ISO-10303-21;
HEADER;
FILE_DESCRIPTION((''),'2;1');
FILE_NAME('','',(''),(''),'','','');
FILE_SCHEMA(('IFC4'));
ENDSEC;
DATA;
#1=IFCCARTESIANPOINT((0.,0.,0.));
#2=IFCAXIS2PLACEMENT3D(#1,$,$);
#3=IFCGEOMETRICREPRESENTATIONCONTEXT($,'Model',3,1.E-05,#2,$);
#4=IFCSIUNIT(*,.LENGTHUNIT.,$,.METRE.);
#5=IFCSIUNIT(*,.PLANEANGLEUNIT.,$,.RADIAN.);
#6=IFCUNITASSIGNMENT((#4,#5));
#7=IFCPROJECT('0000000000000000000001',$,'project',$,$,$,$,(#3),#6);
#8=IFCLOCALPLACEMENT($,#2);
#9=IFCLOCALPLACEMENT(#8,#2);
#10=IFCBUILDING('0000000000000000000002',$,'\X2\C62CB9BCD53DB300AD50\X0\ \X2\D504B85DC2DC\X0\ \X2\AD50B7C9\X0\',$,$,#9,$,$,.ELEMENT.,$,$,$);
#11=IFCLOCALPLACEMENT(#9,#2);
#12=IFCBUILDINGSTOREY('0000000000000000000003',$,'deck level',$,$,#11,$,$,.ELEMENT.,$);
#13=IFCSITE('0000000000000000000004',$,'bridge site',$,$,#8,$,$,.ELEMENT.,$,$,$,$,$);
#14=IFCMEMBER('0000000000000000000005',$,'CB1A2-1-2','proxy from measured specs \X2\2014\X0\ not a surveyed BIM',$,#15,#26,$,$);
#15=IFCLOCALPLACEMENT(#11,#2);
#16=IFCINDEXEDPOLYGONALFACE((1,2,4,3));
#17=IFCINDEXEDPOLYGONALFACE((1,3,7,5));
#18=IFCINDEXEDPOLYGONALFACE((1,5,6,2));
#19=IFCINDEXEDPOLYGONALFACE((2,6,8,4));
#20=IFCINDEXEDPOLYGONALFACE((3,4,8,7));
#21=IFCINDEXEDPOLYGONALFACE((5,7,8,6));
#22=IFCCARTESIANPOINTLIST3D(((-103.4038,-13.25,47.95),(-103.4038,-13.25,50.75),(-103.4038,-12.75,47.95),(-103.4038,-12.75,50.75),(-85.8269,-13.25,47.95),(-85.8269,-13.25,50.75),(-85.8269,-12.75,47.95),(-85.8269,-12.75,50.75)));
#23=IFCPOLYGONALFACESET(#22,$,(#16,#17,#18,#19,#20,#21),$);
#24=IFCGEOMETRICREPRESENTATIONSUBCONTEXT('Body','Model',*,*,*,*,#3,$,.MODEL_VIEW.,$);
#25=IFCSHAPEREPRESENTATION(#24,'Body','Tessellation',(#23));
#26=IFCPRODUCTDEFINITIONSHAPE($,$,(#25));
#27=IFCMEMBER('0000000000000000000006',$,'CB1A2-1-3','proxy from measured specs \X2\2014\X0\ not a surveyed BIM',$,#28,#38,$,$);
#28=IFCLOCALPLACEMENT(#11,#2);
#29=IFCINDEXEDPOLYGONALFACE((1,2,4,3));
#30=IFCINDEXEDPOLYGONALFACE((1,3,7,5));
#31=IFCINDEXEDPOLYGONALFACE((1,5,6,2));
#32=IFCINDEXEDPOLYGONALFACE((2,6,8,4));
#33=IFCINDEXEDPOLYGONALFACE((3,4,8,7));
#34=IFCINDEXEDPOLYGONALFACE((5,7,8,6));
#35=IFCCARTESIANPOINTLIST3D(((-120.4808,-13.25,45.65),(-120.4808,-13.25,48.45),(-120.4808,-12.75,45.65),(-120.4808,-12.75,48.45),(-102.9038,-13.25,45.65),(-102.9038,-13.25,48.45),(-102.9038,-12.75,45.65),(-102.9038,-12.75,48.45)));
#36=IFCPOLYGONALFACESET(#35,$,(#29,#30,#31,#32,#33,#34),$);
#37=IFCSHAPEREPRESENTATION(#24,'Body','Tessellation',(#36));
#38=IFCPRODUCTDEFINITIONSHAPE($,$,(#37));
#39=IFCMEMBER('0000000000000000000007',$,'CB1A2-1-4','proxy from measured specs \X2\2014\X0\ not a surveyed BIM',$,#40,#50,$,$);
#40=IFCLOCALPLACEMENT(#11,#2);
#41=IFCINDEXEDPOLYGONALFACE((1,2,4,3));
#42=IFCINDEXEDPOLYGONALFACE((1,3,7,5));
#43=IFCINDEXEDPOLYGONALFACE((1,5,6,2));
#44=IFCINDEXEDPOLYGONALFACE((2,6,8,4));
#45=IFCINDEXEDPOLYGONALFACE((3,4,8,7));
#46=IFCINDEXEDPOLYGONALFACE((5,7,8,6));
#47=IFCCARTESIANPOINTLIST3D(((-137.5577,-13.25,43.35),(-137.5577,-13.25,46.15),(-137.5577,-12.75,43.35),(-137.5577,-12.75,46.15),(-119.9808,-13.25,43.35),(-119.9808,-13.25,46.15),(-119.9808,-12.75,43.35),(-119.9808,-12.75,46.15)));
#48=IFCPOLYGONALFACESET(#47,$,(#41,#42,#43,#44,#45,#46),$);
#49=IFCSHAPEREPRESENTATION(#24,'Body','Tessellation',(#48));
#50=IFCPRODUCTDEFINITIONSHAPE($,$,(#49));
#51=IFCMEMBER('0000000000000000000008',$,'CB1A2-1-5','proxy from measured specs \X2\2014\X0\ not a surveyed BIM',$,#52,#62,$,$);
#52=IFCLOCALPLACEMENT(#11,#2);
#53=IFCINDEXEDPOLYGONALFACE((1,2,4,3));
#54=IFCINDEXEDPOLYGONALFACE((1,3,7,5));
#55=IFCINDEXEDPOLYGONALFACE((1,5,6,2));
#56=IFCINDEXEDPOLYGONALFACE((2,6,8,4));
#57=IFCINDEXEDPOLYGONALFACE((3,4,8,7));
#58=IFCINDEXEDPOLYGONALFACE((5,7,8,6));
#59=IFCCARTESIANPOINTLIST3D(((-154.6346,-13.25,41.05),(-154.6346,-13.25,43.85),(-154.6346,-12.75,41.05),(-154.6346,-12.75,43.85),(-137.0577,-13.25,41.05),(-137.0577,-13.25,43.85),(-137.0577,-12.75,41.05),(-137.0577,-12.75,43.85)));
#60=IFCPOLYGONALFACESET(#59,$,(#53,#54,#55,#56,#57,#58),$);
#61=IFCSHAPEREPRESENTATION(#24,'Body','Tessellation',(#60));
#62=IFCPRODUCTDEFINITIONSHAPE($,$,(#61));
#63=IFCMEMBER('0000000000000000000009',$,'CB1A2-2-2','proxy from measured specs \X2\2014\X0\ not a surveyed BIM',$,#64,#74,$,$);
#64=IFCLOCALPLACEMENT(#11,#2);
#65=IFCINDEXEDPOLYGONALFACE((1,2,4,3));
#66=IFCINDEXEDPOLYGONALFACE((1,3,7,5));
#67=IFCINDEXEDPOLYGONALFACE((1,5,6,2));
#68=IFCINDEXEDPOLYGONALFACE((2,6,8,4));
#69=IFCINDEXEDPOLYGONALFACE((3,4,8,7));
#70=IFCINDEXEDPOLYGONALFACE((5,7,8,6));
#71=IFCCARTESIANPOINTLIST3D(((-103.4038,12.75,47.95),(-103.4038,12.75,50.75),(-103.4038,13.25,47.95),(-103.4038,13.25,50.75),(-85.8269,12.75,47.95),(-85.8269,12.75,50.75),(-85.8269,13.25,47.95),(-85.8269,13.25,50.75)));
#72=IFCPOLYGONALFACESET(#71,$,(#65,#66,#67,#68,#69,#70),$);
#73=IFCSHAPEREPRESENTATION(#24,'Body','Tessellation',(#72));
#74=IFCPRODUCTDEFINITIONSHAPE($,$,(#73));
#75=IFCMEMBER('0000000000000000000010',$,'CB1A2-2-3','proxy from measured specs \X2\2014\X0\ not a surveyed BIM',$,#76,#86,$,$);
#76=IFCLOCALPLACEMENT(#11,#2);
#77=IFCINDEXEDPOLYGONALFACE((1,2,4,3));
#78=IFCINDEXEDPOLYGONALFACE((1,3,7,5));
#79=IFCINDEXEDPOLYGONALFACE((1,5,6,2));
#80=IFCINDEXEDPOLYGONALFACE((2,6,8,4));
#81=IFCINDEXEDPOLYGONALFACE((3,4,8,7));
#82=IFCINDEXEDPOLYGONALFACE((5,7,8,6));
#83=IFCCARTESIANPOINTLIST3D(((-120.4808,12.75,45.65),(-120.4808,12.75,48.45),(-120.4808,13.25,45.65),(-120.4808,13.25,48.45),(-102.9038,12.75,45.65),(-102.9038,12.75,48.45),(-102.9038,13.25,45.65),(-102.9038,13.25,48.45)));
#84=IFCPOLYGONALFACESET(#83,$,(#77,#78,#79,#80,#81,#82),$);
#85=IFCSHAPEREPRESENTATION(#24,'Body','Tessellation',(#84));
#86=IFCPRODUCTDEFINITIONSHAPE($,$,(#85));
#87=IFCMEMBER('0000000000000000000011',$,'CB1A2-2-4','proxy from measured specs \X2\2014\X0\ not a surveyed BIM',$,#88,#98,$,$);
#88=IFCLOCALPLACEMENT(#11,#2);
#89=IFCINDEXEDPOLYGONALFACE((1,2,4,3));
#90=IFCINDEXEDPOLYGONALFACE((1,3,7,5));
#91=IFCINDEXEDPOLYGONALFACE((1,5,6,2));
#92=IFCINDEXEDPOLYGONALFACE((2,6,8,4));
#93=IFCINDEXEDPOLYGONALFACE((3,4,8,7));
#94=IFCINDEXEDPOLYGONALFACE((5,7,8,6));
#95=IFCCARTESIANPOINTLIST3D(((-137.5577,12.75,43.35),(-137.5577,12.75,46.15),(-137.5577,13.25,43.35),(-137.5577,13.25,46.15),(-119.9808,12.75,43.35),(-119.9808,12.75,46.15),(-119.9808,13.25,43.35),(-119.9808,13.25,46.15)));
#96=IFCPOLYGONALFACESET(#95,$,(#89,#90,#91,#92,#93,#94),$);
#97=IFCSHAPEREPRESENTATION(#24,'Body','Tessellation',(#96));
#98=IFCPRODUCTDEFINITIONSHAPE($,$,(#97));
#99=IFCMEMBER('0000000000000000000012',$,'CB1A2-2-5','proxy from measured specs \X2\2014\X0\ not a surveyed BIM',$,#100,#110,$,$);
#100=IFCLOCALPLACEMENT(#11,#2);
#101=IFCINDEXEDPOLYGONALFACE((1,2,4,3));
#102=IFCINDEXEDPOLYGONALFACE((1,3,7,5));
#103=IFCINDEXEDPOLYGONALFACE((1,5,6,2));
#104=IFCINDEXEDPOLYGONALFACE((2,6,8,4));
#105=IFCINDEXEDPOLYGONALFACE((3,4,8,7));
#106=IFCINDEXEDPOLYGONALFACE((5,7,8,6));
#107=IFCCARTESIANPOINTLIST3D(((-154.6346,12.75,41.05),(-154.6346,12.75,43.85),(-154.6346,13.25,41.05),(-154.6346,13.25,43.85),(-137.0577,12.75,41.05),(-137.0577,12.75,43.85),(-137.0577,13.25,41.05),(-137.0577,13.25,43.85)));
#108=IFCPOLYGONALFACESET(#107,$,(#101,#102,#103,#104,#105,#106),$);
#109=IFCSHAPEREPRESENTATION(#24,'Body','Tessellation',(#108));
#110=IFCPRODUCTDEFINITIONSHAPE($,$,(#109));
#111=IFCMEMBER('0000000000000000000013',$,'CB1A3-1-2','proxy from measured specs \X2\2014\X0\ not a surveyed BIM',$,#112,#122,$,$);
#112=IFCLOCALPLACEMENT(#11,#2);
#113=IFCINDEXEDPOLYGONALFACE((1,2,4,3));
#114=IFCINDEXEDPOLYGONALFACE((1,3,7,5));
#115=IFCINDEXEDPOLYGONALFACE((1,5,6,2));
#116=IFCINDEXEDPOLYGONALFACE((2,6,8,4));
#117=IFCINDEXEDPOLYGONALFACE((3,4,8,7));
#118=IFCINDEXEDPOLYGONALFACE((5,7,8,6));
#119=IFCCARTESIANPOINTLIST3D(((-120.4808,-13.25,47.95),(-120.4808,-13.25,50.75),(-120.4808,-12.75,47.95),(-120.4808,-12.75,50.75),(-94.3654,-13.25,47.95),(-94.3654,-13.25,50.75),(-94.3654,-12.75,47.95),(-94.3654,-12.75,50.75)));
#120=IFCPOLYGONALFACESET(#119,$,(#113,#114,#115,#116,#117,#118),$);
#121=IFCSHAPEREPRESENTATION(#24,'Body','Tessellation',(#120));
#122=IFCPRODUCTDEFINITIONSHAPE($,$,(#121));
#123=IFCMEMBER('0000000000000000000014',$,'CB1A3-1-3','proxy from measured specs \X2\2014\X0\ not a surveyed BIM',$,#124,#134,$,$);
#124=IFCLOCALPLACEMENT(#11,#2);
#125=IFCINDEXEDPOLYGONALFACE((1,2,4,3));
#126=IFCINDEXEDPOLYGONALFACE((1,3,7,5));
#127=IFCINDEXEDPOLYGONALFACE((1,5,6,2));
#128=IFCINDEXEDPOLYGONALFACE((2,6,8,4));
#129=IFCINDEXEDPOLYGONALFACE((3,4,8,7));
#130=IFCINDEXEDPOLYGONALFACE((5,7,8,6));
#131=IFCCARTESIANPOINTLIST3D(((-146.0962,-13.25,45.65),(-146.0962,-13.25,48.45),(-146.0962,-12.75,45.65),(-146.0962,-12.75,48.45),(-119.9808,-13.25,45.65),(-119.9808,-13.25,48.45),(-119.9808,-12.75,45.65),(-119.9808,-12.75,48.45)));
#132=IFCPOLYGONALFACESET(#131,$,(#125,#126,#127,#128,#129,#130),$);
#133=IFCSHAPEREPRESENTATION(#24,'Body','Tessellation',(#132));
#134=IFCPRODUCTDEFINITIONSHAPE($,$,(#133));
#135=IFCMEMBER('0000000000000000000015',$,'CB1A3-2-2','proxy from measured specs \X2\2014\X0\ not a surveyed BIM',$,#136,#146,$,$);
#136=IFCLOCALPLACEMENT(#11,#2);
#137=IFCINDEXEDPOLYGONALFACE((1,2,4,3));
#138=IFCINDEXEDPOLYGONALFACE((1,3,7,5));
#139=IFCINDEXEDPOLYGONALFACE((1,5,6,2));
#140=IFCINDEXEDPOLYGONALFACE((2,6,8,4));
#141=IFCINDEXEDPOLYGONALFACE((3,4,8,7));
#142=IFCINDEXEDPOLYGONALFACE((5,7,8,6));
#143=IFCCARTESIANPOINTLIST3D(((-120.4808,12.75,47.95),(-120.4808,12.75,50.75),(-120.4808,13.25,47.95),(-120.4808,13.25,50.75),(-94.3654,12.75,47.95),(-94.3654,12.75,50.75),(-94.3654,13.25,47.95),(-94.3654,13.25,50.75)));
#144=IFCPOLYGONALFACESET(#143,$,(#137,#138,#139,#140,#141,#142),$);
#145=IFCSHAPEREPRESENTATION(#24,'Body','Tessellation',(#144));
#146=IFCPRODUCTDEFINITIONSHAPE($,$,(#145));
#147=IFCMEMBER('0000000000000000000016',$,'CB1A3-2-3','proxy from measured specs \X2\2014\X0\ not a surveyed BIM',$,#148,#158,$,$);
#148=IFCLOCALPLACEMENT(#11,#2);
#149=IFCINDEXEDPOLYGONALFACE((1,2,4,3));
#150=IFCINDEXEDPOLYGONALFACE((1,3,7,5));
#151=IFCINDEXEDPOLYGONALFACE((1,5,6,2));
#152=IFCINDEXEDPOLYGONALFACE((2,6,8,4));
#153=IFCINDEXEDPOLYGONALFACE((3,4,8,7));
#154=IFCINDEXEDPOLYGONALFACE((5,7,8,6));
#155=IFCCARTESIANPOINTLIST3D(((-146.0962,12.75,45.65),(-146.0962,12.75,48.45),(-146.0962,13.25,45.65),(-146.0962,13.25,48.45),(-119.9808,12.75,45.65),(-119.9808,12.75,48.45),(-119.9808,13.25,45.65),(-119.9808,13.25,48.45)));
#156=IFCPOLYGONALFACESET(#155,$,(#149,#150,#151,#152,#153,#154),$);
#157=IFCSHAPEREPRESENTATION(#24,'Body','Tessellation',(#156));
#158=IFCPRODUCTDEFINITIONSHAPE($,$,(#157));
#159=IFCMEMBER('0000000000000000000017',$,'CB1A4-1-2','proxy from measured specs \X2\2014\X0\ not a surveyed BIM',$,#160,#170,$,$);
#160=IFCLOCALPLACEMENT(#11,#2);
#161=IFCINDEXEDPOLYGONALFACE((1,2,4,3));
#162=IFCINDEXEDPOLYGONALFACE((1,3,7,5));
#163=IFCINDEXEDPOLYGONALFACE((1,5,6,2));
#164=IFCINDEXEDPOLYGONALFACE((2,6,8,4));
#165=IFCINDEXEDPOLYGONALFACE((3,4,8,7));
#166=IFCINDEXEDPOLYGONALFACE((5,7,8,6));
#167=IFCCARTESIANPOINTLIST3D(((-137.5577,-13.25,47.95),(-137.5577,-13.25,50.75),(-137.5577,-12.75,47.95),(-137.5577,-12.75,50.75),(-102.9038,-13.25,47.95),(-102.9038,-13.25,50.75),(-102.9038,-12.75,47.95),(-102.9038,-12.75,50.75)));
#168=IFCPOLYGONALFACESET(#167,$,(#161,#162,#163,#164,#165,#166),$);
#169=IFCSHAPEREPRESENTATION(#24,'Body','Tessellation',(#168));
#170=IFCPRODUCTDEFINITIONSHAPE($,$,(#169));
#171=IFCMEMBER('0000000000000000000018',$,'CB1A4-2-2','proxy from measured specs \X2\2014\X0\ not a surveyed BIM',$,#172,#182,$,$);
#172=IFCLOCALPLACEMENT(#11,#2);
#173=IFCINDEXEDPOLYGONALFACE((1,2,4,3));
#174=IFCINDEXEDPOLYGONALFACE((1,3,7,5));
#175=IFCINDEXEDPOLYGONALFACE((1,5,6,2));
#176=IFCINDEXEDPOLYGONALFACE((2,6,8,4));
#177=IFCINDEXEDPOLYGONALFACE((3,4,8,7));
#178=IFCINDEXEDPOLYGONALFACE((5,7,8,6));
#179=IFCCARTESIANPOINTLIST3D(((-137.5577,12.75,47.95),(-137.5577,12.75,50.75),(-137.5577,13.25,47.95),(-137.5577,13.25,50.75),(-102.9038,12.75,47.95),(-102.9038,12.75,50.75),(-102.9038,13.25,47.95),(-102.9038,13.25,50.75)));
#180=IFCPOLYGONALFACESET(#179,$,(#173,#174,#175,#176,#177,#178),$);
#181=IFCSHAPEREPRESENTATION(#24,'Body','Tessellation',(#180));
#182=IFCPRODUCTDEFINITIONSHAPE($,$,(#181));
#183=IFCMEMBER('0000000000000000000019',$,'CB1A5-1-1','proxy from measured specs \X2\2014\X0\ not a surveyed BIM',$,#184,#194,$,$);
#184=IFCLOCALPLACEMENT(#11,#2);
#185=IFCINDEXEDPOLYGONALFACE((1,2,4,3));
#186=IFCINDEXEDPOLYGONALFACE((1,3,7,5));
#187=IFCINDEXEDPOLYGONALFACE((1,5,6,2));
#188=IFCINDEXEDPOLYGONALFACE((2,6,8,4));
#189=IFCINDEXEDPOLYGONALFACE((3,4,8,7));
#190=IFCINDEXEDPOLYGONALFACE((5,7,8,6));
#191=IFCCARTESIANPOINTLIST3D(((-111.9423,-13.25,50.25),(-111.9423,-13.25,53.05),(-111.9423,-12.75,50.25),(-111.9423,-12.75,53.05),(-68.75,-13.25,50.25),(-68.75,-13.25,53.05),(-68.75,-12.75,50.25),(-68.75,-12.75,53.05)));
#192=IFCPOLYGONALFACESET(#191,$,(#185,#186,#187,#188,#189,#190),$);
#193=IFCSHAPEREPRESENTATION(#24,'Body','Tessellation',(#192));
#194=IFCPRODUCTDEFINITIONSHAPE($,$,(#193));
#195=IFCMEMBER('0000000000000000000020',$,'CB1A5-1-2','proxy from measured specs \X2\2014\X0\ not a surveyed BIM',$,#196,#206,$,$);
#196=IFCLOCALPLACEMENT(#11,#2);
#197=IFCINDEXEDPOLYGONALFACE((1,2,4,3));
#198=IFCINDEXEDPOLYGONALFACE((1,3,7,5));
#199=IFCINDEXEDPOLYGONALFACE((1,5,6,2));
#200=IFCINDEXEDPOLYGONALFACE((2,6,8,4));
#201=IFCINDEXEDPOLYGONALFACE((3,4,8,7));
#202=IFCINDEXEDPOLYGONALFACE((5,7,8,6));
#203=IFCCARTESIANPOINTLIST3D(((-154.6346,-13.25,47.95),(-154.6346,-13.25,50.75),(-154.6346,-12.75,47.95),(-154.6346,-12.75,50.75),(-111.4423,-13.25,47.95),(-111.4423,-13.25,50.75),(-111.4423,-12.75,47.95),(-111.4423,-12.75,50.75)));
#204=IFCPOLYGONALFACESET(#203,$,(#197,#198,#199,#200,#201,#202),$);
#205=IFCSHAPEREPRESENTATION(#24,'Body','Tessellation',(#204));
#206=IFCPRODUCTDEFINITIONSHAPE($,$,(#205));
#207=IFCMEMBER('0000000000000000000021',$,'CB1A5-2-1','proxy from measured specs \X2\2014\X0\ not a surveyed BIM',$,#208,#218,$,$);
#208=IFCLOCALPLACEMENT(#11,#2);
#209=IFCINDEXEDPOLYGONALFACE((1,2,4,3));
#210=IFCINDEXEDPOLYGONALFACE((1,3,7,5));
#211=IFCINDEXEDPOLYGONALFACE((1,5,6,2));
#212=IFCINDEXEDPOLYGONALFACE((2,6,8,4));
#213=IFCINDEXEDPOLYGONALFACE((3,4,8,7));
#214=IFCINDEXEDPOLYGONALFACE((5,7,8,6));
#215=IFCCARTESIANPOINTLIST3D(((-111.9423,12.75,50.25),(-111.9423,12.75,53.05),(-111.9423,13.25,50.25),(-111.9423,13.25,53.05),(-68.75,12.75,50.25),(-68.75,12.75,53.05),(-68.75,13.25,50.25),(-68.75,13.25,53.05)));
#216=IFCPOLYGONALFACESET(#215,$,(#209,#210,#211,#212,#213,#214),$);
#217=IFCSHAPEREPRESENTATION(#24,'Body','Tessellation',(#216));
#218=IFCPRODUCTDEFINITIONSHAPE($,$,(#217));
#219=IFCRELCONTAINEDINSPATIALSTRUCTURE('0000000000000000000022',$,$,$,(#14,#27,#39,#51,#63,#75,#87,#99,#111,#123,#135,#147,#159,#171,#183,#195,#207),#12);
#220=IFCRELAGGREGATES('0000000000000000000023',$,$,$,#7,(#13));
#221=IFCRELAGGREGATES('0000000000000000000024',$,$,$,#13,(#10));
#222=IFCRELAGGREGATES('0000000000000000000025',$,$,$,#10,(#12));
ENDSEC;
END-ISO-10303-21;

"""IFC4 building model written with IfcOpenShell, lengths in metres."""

from ifc_helpers import new_model, si_unit, frame, origin, origin_2d, place, context, subcontext, project, spatial, rectangle, extrude, element, save


model = new_model("IFC4")

# Units and contexts
model_context = context("Model", 3, precision=1e-05, world=origin())
body_context = subcontext(model_context, "Body", "Model", "MODEL_VIEW")
ifc_project = project(units=[si_unit("LENGTHUNIT", "METRE"), si_unit("PLANEANGLEUNIT", "RADIAN")], contexts=[model_context])

# Site, building, storey
site_placement = place(None, origin())
site = spatial("IfcSite", under=ifc_project, at=site_placement, Name="bridge site", CompositionType="ELEMENT")
building_placement = place(site_placement, origin())
building = spatial("IfcBuilding", under=site, at=building_placement, Name="올림픽대교 프록시 교량", CompositionType="ELEMENT")
storey_placement = place(building_placement, origin())
storey = spatial("IfcBuildingStorey", under=building, at=storey_placement, Name="deck level", CompositionType="ELEMENT")

# Members
member_1_placement = place(storey_placement, frame((-94.6154, -13.0, 47.95)))
element("IfcMember", 1, at=member_1_placement, inside=storey, Name="CB1A2-1-2", Description="proxy from measured specs — not a surveyed BIM", context=body_context, shape_type="SweptSolid", body=[
    extrude(rectangle(XDim=17.5769, YDim=0.5, at=origin_2d()), origin(), (0.0, 0.0, 1.0), 2.8),
])
member_2_placement = place(storey_placement, frame((-111.6923, -13.0, 45.65)))
element("IfcMember", 2, at=member_2_placement, inside=storey, Name="CB1A2-1-3", Description="proxy from measured specs — not a surveyed BIM", context=body_context, shape_type="SweptSolid", body=[
    extrude(rectangle(XDim=17.5769, YDim=0.5, at=origin_2d()), origin(), (0.0, 0.0, 1.0), 2.8),
])
member_3_placement = place(storey_placement, frame((-128.7692, -13.0, 43.35)))
element("IfcMember", 3, at=member_3_placement, inside=storey, Name="CB1A2-1-4", Description="proxy from measured specs — not a surveyed BIM", context=body_context, shape_type="SweptSolid", body=[
    extrude(rectangle(XDim=17.5769, YDim=0.5, at=origin_2d()), origin(), (0.0, 0.0, 1.0), 2.8),
])
member_4_placement = place(storey_placement, frame((-145.8462, -13.0, 41.05)))
element("IfcMember", 4, at=member_4_placement, inside=storey, Name="CB1A2-1-5", Description="proxy from measured specs — not a surveyed BIM", context=body_context, shape_type="SweptSolid", body=[
    extrude(rectangle(XDim=17.5769, YDim=0.5, at=origin_2d()), origin(), (0.0, 0.0, 1.0), 2.8),
])
member_5_placement = place(storey_placement, frame((-94.6154, 13.0, 47.95)))
element("IfcMember", 5, at=member_5_placement, inside=storey, Name="CB1A2-2-2", Description="proxy from measured specs — not a surveyed BIM", context=body_context, shape_type="SweptSolid", body=[
    extrude(rectangle(XDim=17.5769, YDim=0.5, at=origin_2d()), origin(), (0.0, 0.0, 1.0), 2.8),
])
member_6_placement = place(storey_placement, frame((-111.6923, 13.0, 45.65)))
element("IfcMember", 6, at=member_6_placement, inside=storey, Name="CB1A2-2-3", Description="proxy from measured specs — not a surveyed BIM", context=body_context, shape_type="SweptSolid", body=[
    extrude(rectangle(XDim=17.5769, YDim=0.5, at=origin_2d()), origin(), (0.0, 0.0, 1.0), 2.8),
])
member_7_placement = place(storey_placement, frame((-128.7692, 13.0, 43.35)))
element("IfcMember", 7, at=member_7_placement, inside=storey, Name="CB1A2-2-4", Description="proxy from measured specs — not a surveyed BIM", context=body_context, shape_type="SweptSolid", body=[
    extrude(rectangle(XDim=17.5769, YDim=0.5, at=origin_2d()), origin(), (0.0, 0.0, 1.0), 2.8),
])
member_8_placement = place(storey_placement, frame((-145.8462, 13.0, 41.05)))
element("IfcMember", 8, at=member_8_placement, inside=storey, Name="CB1A2-2-5", Description="proxy from measured specs — not a surveyed BIM", context=body_context, shape_type="SweptSolid", body=[
    extrude(rectangle(XDim=17.5769, YDim=0.5, at=origin_2d()), origin(), (0.0, 0.0, 1.0), 2.8),
])
member_9_placement = place(storey_placement, frame((-107.4231, -13.0, 47.95)))
element("IfcMember", 9, at=member_9_placement, inside=storey, Name="CB1A3-1-2", Description="proxy from measured specs — not a surveyed BIM", context=body_context, shape_type="SweptSolid", body=[
    extrude(rectangle(XDim=26.1154, YDim=0.5, at=origin_2d()), origin(), (0.0, 0.0, 1.0), 2.8),
])
member_10_placement = place(storey_placement, frame((-133.0385, -13.0, 45.65)))
element("IfcMember", 10, at=member_10_placement, inside=storey, Name="CB1A3-1-3", Description="proxy from measured specs — not a surveyed BIM", context=body_context, shape_type="SweptSolid", body=[
    extrude(rectangle(XDim=26.1154, YDim=0.5, at=origin_2d()), origin(), (0.0, 0.0, 1.0), 2.8),
])
member_11_placement = place(storey_placement, frame((-107.4231, 13.0, 47.95)))
element("IfcMember", 11, at=member_11_placement, inside=storey, Name="CB1A3-2-2", Description="proxy from measured specs — not a surveyed BIM", context=body_context, shape_type="SweptSolid", body=[
    extrude(rectangle(XDim=26.1154, YDim=0.5, at=origin_2d()), origin(), (0.0, 0.0, 1.0), 2.8),
])
member_12_placement = place(storey_placement, frame((-133.0385, 13.0, 45.65)))
element("IfcMember", 12, at=member_12_placement, inside=storey, Name="CB1A3-2-3", Description="proxy from measured specs — not a surveyed BIM", context=body_context, shape_type="SweptSolid", body=[
    extrude(rectangle(XDim=26.1154, YDim=0.5, at=origin_2d()), origin(), (0.0, 0.0, 1.0), 2.8),
])
for number, where, name in (
    (13, (-120.2308, -13.0, 47.95), "CB1A4-1-2"),
    (14, (-120.2308, 13.0, 47.95), "CB1A4-2-2"),
):
    element("IfcMember", number, at=place(storey_placement, frame(where)), inside=storey, Name=name, Description="proxy from measured specs — not a surveyed BIM", context=body_context, shape_type="SweptSolid", body=[
        extrude(rectangle(XDim=34.6538, YDim=0.5, at=origin_2d()), origin(), (0.0, 0.0, 1.0), 2.8),
    ])
member_13_placement = place(storey_placement, frame((-90.3462, -13.0, 50.25)))
element("IfcMember", 15, at=member_13_placement, inside=storey, Name="CB1A5-1-1", Description="proxy from measured specs — not a surveyed BIM", context=body_context, shape_type="SweptSolid", body=[
    extrude(rectangle(XDim=43.1923, YDim=0.5, at=origin_2d()), origin(), (0.0, 0.0, 1.0), 2.8),
])
member_14_placement = place(storey_placement, frame((-133.0385, -13.0, 47.95)))
element("IfcMember", 16, at=member_14_placement, inside=storey, Name="CB1A5-1-2", Description="proxy from measured specs — not a surveyed BIM", context=body_context, shape_type="SweptSolid", body=[
    extrude(rectangle(XDim=43.1923, YDim=0.5, at=origin_2d()), origin(), (0.0, 0.0, 1.0), 2.8),
])
member_15_placement = place(storey_placement, frame((-90.3462, 13.0, 50.25)))
element("IfcMember", 17, at=member_15_placement, inside=storey, Name="CB1A5-2-1", Description="proxy from measured specs — not a surveyed BIM", context=body_context, shape_type="SweptSolid", body=[
    extrude(rectangle(XDim=43.1923, YDim=0.5, at=origin_2d()), origin(), (0.0, 0.0, 1.0), 2.8),
])

save(model, "model.ifc")
